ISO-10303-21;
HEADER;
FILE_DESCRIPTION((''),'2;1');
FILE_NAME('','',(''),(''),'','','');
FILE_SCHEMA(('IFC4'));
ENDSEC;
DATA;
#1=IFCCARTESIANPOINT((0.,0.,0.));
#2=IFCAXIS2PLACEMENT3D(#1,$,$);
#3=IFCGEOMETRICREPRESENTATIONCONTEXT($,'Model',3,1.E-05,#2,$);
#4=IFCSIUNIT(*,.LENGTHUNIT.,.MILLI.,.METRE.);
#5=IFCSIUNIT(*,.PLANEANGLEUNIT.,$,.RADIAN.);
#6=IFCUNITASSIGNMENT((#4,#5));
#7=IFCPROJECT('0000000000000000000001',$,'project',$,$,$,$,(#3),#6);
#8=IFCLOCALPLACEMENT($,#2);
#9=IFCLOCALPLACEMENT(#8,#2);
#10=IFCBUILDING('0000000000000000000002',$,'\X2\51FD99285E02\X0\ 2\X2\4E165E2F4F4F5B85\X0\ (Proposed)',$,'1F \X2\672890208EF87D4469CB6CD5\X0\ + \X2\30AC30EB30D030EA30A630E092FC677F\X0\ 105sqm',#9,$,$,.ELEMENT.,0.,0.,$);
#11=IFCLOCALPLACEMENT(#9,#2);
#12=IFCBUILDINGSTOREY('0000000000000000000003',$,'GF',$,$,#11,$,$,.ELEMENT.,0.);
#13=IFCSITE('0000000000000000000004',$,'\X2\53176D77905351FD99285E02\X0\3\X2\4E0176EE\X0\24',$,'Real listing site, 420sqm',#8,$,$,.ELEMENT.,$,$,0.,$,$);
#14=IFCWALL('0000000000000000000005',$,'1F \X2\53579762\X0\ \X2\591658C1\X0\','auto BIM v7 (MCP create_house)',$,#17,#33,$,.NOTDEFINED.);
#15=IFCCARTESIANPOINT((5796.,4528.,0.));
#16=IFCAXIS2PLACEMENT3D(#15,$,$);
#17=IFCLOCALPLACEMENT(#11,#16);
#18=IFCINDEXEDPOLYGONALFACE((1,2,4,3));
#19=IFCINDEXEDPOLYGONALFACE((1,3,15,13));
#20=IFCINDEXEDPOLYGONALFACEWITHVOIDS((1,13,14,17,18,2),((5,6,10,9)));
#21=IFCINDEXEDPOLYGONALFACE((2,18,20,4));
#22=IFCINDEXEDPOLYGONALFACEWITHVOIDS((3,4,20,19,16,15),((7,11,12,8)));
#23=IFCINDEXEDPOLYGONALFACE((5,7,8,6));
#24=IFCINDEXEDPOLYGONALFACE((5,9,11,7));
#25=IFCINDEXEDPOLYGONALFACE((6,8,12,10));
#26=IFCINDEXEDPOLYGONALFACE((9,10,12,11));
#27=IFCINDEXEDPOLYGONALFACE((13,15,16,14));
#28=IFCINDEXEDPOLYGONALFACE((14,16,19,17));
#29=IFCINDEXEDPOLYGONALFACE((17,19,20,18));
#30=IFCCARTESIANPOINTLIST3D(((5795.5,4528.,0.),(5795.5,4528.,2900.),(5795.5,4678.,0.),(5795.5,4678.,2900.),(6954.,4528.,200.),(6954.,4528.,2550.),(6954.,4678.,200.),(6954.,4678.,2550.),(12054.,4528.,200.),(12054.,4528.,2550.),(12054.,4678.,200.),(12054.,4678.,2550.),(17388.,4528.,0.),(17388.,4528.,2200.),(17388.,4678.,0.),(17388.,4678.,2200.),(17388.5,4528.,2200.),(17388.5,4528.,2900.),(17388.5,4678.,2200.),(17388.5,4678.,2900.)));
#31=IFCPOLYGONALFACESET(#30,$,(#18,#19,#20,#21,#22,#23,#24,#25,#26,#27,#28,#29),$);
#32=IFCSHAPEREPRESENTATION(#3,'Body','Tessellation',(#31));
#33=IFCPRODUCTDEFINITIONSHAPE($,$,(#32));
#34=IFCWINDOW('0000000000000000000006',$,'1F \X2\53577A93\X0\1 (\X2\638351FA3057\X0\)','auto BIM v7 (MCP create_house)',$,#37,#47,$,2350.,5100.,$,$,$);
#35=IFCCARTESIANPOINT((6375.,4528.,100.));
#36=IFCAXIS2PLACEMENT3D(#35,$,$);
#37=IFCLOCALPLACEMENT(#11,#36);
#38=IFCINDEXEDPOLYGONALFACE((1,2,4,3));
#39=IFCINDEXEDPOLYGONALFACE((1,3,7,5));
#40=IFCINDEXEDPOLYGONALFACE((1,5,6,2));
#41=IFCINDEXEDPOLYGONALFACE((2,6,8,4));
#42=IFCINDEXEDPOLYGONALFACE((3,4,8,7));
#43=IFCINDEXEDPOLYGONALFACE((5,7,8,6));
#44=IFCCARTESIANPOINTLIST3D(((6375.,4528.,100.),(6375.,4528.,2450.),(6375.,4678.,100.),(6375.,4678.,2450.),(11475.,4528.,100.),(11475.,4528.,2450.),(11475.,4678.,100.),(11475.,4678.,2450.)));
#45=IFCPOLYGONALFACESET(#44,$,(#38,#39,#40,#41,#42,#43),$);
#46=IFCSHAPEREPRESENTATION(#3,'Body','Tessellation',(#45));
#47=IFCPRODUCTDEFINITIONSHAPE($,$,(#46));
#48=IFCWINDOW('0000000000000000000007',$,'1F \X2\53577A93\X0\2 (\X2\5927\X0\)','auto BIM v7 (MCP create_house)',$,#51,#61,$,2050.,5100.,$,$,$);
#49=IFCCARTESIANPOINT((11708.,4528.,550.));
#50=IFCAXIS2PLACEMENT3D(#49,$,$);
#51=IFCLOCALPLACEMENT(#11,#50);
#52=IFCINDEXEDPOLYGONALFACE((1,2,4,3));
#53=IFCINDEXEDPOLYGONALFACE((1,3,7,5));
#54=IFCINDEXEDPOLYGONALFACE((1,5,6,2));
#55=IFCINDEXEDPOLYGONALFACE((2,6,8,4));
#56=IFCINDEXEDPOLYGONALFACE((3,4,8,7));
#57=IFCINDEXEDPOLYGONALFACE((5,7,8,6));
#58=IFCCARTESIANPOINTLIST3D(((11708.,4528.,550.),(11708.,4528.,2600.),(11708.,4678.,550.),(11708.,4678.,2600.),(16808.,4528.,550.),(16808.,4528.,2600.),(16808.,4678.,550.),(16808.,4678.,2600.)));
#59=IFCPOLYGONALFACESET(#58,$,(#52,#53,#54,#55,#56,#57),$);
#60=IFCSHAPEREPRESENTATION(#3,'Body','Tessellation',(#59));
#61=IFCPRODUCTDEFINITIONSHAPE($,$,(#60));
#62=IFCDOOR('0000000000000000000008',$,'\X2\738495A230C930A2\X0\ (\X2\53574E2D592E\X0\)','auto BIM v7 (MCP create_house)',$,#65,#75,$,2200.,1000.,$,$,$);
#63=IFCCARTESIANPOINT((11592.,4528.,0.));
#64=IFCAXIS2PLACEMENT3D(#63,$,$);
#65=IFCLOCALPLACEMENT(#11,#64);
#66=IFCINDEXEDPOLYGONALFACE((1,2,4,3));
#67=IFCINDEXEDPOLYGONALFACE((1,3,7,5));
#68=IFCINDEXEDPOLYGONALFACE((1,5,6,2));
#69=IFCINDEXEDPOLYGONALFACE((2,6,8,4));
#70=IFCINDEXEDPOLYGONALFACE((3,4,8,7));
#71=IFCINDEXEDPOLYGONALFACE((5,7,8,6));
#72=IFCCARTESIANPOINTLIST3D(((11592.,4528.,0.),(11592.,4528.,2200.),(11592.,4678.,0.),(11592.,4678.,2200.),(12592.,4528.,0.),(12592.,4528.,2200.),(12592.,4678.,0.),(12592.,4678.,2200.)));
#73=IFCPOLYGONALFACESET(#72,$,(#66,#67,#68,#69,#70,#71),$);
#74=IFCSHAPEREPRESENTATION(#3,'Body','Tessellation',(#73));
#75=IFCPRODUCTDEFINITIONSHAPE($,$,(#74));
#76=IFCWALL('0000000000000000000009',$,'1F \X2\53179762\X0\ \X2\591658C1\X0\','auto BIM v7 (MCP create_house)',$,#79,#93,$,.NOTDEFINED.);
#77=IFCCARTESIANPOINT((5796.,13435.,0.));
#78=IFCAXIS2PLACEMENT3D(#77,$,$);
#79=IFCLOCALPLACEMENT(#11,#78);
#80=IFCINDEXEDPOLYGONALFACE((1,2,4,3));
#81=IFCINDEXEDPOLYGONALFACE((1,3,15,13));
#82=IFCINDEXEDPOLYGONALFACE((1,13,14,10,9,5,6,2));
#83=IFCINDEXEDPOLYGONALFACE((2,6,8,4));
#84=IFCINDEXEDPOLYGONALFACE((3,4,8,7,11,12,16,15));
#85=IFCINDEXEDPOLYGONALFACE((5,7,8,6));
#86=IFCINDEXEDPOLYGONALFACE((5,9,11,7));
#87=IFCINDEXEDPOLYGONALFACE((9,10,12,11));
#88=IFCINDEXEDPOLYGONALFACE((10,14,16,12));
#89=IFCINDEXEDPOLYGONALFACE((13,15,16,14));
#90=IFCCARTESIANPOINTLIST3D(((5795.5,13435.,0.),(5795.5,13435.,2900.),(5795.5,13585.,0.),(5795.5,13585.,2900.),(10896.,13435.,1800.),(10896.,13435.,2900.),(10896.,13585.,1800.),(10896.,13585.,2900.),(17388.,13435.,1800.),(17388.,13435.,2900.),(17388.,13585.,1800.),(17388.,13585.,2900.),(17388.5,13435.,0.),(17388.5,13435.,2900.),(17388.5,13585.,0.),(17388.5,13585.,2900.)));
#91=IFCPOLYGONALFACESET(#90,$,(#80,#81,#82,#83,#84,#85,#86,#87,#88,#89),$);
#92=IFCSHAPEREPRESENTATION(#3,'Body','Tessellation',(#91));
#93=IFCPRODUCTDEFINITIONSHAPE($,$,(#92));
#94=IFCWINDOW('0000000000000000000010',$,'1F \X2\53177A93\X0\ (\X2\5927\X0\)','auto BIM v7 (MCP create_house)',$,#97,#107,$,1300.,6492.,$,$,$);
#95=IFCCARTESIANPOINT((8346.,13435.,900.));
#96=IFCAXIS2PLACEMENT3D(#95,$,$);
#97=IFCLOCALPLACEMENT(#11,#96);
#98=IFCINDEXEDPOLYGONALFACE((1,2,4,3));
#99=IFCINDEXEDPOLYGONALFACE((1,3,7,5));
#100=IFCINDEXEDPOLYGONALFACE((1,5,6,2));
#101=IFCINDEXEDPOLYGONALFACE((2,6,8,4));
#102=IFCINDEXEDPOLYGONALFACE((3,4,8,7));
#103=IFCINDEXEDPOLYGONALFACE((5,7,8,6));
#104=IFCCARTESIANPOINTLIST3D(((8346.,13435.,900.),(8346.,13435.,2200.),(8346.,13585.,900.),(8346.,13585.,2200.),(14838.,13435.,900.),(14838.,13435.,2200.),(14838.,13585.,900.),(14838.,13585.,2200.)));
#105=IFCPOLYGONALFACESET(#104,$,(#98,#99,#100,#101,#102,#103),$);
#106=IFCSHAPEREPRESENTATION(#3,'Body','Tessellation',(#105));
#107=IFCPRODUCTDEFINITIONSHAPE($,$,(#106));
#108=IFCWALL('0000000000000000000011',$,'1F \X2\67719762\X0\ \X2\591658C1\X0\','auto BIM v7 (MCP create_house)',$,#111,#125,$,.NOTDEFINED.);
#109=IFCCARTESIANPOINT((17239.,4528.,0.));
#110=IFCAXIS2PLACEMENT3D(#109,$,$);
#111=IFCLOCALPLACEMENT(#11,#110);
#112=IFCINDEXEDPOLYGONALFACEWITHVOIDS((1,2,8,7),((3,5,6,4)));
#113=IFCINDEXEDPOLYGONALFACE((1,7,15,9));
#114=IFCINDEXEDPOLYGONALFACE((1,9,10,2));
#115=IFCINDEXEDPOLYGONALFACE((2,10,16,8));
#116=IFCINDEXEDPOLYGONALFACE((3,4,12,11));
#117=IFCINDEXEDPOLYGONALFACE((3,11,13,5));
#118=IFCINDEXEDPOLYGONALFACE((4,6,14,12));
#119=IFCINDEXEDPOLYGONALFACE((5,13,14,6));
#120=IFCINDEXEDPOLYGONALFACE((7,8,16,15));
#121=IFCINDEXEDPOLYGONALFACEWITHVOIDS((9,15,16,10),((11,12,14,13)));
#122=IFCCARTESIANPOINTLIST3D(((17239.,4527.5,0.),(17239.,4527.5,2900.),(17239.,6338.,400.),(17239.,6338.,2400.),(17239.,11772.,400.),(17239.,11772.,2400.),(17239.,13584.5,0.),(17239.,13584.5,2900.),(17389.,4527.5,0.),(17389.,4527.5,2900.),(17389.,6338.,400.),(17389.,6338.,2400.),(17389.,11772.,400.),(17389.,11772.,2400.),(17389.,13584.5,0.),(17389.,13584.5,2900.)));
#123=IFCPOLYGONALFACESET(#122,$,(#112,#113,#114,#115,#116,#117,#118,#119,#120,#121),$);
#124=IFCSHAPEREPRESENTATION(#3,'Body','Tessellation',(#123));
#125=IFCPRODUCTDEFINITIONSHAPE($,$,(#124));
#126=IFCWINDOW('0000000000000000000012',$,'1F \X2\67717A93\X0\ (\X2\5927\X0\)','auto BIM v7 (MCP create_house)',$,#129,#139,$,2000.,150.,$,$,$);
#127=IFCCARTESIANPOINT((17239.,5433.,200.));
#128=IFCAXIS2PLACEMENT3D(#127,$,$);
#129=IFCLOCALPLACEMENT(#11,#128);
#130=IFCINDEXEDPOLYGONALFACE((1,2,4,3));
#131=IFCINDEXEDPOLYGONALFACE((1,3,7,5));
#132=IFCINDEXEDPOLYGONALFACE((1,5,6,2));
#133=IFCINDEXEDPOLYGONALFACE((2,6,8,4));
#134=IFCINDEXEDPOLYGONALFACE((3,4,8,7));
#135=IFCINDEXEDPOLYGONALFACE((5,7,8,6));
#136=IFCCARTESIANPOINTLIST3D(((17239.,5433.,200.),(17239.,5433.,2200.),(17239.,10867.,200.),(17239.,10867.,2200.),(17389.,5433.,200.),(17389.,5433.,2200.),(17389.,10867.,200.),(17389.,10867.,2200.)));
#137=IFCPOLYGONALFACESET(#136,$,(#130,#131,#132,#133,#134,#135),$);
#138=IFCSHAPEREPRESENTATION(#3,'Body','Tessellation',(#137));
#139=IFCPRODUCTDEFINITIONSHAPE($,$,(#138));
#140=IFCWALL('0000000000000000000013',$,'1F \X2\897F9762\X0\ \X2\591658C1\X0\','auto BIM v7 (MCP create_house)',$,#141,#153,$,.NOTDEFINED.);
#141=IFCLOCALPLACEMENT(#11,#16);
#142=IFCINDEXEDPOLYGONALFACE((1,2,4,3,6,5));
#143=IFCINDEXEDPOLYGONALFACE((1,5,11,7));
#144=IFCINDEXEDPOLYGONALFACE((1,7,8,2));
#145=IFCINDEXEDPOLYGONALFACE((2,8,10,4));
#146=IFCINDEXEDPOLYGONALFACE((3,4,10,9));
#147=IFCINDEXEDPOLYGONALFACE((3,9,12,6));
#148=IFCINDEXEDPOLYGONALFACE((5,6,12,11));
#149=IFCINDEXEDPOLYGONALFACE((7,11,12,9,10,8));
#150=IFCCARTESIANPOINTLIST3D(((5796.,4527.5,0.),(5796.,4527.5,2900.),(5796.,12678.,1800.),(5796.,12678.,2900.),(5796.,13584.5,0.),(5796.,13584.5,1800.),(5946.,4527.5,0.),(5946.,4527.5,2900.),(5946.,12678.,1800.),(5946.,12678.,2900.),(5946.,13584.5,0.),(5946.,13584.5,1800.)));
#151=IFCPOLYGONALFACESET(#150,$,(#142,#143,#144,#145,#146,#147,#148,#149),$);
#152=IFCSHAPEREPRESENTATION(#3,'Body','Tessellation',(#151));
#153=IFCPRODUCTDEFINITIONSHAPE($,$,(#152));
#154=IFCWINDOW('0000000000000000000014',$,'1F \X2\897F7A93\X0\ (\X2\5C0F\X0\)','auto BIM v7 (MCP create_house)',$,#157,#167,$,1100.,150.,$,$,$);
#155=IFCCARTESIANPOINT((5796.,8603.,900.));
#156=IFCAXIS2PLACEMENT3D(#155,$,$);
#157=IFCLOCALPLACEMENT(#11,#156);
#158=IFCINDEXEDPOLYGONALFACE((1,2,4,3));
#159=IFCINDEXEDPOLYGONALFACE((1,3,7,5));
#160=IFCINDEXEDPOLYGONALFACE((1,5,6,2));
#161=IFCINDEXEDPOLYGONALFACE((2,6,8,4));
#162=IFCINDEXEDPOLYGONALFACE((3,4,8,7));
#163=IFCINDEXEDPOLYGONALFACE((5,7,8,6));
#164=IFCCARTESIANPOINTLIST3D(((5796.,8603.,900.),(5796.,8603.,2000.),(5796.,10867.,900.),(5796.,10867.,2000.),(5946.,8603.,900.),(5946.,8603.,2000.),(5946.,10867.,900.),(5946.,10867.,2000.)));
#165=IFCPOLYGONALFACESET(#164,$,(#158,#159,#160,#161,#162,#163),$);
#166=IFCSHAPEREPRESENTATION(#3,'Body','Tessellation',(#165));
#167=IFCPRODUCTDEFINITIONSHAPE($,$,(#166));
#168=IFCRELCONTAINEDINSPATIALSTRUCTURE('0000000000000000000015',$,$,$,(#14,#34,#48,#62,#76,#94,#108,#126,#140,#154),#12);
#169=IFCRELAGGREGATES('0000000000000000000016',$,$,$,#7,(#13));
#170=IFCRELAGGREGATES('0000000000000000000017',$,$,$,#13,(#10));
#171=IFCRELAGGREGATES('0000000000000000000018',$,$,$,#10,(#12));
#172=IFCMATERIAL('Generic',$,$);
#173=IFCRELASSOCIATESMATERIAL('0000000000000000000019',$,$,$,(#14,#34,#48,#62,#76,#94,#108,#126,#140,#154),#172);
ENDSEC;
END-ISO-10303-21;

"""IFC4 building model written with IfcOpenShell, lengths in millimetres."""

from ifc_helpers import new_model, si_unit, frame, frame_2d, origin, place, context, project, spatial, rectangle, extrude, material, element, fill, save


model = new_model("IFC4")

# Units and contexts
model_context = context("Model", 3, precision=1e-05, world=origin())
ifc_project = project(units=[si_unit("LENGTHUNIT", "METRE", prefix="MILLI"), si_unit("PLANEANGLEUNIT", "RADIAN")], contexts=[model_context])

# Site, building, storey
site_placement = place(None, origin())
site = spatial("IfcSite", under=ifc_project, at=site_placement, Name="北海道函館市3丁目24", ObjectType="Real listing site, 420sqm", CompositionType="ELEMENT", RefElevation=0.0)
building_placement = place(site_placement, origin())
building = spatial("IfcBuilding", under=site, at=building_placement, Name="函館市 2世帯住宅 (Proposed)", ObjectType="1F 木造軸組構法 + ガルバリウム鋼板 105sqm", CompositionType="ELEMENT", ElevationOfRefHeight=0.0, ElevationOfTerrain=0.0)
storey_placement = place(building_placement, origin())
storey = spatial("IfcBuildingStorey", under=building, at=storey_placement, Name="GF", CompositionType="ELEMENT", Elevation=0.0)

# Shared definitions
ifc_material = material(Name="Generic")

# Wall, openings, windows, door
wall_1_placement = place(storey_placement, frame((5796.0, 4528.0, 0.0)))
wall_1 = element("IfcWall", 1, at=wall_1_placement, inside=storey, material=ifc_material, Name="1F 南面 外壁", Description="auto BIM v7 (MCP create_house)", PredefinedType="NOTDEFINED", context=model_context, shape_type="SweptSolid", body=[
    extrude(rectangle(XDim=11593.0, YDim=150.0, at=frame_2d((5796.0, 75.0))), frame((5796.0, 4528.0, 0.0)), (0.0, 0.0, 1.0), 2900.0),
])
opening_1_placement = place(storey_placement, frame((6375.0, 4528.0, 100.0)))
opening_1 = element("IfcOpeningElement", 2, at=opening_1_placement, cuts=wall_1, PredefinedType="NOTDEFINED", context=model_context, shape_type="SweptSolid", body=[
    extrude(rectangle(XDim=5100.0, YDim=150.0, at=frame_2d((2550.0, 75.0))), frame((6375.0, 4528.0, 100.0)), (0.0, 0.0, 1.0), 2350.0),
])
opening_2_placement = place(storey_placement, frame((11708.0, 4528.0, 550.0)))
opening_2 = element("IfcOpeningElement", 3, at=opening_2_placement, cuts=wall_1, PredefinedType="NOTDEFINED", context=model_context, shape_type="SweptSolid", body=[
    extrude(rectangle(XDim=5100.0, YDim=150.0, at=frame_2d((2550.0, 75.0))), frame((11708.0, 4528.0, 550.0)), (0.0, 0.0, 1.0), 2050.0),
])
opening_3_placement = place(storey_placement, frame((11592.0, 4528.0, 0.0)))
opening_3 = element("IfcOpeningElement", 4, at=opening_3_placement, cuts=wall_1, PredefinedType="NOTDEFINED", context=model_context, shape_type="SweptSolid", body=[
    extrude(rectangle(XDim=1000.0, YDim=150.0, at=frame_2d((500.0, 75.0))), frame((11592.0, 4528.0, 0.0)), (0.0, 0.0, 1.0), 2200.0),
])
window_1_placement = place(storey_placement, frame((6375.0, 4528.0, 100.0)))
window_1 = element("IfcWindow", 5, at=window_1_placement, inside=storey, material=ifc_material, Name="1F 南窓1 (掃出し)", Description="auto BIM v7 (MCP create_house)", OverallHeight=2350.0, OverallWidth=5100.0, context=model_context, shape_type="SweptSolid", body=[
    extrude(rectangle(XDim=5100.0, YDim=150.0, at=frame_2d((2550.0, 75.0))), frame((6375.0, 4528.0, 100.0)), (0.0, 0.0, 1.0), 2350.0),
])
fill(opening_1, window_1)
window_2_placement = place(storey_placement, frame((11708.0, 4528.0, 550.0)))
window_2 = element("IfcWindow", 6, at=window_2_placement, inside=storey, material=ifc_material, Name="1F 南窓2 (大)", Description="auto BIM v7 (MCP create_house)", OverallHeight=2050.0, OverallWidth=5100.0, context=model_context, shape_type="SweptSolid", body=[
    extrude(rectangle(XDim=5100.0, YDim=150.0, at=frame_2d((2550.0, 75.0))), frame((11708.0, 4528.0, 550.0)), (0.0, 0.0, 1.0), 2050.0),
])
fill(opening_2, window_2)
door_placement = place(storey_placement, frame((11592.0, 4528.0, 0.0)))
door = element("IfcDoor", 7, at=door_placement, inside=storey, material=ifc_material, Name="玄関ドア (南中央)", Description="auto BIM v7 (MCP create_house)", OverallHeight=2200.0, OverallWidth=1000.0, context=model_context, shape_type="SweptSolid", body=[
    extrude(rectangle(XDim=1000.0, YDim=150.0, at=frame_2d((500.0, 75.0))), frame((11592.0, 4528.0, 0.0)), (0.0, 0.0, 1.0), 2200.0),
])
fill(opening_3, door)

# Walls, openings, windows
wall_2_placement = place(storey_placement, frame((5796.0, 13435.0, 0.0)))
wall_2 = element("IfcWall", 8, at=wall_2_placement, inside=storey, material=ifc_material, Name="1F 北面 外壁", Description="auto BIM v7 (MCP create_house)", PredefinedType="NOTDEFINED", context=model_context, shape_type="SweptSolid", body=[
    extrude(rectangle(XDim=11593.0, YDim=150.0, at=frame_2d((5796.0, 75.0))), frame((5796.0, 13435.0, 0.0)), (0.0, 0.0, 1.0), 2900.0),
])
opening_4_placement = place(storey_placement, frame((8346.0, 13435.0, 900.0)))
opening_4 = element("IfcOpeningElement", 9, at=opening_4_placement, cuts=wall_2, PredefinedType="NOTDEFINED", context=model_context, shape_type="SweptSolid", body=[
    extrude(rectangle(XDim=6492.0, YDim=150.0, at=frame_2d((3246.0, 75.0))), frame((8346.0, 13435.0, 900.0)), (0.0, 0.0, 1.0), 1300.0),
])
window_3_placement = place(storey_placement, frame((8346.0, 13435.0, 900.0)))
window_3 = element("IfcWindow", 10, at=window_3_placement, inside=storey, material=ifc_material, Name="1F 北窓 (大)", Description="auto BIM v7 (MCP create_house)", OverallHeight=1300.0, OverallWidth=6492.0, context=model_context, shape_type="SweptSolid", body=[
    extrude(rectangle(XDim=6492.0, YDim=150.0, at=frame_2d((3246.0, 75.0))), frame((8346.0, 13435.0, 900.0)), (0.0, 0.0, 1.0), 1300.0),
])
fill(opening_4, window_3)
wall_3_placement = place(storey_placement, frame((17239.0, 4528.0, 0.0)))
wall_3 = element("IfcWall", 11, at=wall_3_placement, inside=storey, material=ifc_material, Name="1F 東面 外壁", Description="auto BIM v7 (MCP create_house)", PredefinedType="NOTDEFINED", context=model_context, shape_type="SweptSolid", body=[
    extrude(rectangle(XDim=150.0, YDim=9057.0, at=frame_2d((75.0, 4528.0))), frame((17239.0, 4528.0, 0.0)), (0.0, 0.0, 1.0), 2900.0),
])
opening_5_placement = place(storey_placement, frame((17239.0, 5433.0, 200.0)))
opening_5 = element("IfcOpeningElement", 12, at=opening_5_placement, cuts=wall_3, PredefinedType="NOTDEFINED", context=model_context, shape_type="SweptSolid", body=[
    extrude(rectangle(XDim=150.0, YDim=5434.0, at=frame_2d((75.0, 2717.0))), frame((17239.0, 5433.0, 200.0)), (0.0, 0.0, 1.0), 2000.0),
])
window_4_placement = place(storey_placement, frame((17239.0, 5433.0, 200.0)))
window_4 = element("IfcWindow", 13, at=window_4_placement, inside=storey, material=ifc_material, Name="1F 東窓 (大)", Description="auto BIM v7 (MCP create_house)", OverallHeight=2000.0, OverallWidth=150.0, context=model_context, shape_type="SweptSolid", body=[
    extrude(rectangle(XDim=150.0, YDim=5434.0, at=frame_2d((75.0, 2717.0))), frame((17239.0, 5433.0, 200.0)), (0.0, 0.0, 1.0), 2000.0),
])
fill(opening_5, window_4)
wall_4_placement = place(storey_placement, frame((5796.0, 4528.0, 0.0)))
wall_4 = element("IfcWall", 14, at=wall_4_placement, inside=storey, material=ifc_material, Name="1F 西面 外壁", Description="auto BIM v7 (MCP create_house)", PredefinedType="NOTDEFINED", context=model_context, shape_type="SweptSolid", body=[
    extrude(rectangle(XDim=150.0, YDim=9057.0, at=frame_2d((75.0, 4528.0))), frame((5796.0, 4528.0, 0.0)), (0.0, 0.0, 1.0), 2900.0),
])
opening_6_placement = place(storey_placement, frame((5796.0, 8603.0, 900.0)))
opening_6 = element("IfcOpeningElement", 15, at=opening_6_placement, cuts=wall_4, PredefinedType="NOTDEFINED", context=model_context, shape_type="SweptSolid", body=[
    extrude(rectangle(XDim=150.0, YDim=2264.0, at=frame_2d((75.0, 1132.0))), frame((5796.0, 8603.0, 900.0)), (0.0, 0.0, 1.0), 1100.0),
])
window_5_placement = place(storey_placement, frame((5796.0, 8603.0, 900.0)))
window_5 = element("IfcWindow", 16, at=window_5_placement, inside=storey, material=ifc_material, Name="1F 西窓 (小)", Description="auto BIM v7 (MCP create_house)", OverallHeight=1100.0, OverallWidth=150.0, context=model_context, shape_type="SweptSolid", body=[
    extrude(rectangle(XDim=150.0, YDim=2264.0, at=frame_2d((75.0, 1132.0))), frame((5796.0, 8603.0, 900.0)), (0.0, 0.0, 1.0), 1100.0),
])
fill(opening_6, window_5)

save(model, "model.ifc")
